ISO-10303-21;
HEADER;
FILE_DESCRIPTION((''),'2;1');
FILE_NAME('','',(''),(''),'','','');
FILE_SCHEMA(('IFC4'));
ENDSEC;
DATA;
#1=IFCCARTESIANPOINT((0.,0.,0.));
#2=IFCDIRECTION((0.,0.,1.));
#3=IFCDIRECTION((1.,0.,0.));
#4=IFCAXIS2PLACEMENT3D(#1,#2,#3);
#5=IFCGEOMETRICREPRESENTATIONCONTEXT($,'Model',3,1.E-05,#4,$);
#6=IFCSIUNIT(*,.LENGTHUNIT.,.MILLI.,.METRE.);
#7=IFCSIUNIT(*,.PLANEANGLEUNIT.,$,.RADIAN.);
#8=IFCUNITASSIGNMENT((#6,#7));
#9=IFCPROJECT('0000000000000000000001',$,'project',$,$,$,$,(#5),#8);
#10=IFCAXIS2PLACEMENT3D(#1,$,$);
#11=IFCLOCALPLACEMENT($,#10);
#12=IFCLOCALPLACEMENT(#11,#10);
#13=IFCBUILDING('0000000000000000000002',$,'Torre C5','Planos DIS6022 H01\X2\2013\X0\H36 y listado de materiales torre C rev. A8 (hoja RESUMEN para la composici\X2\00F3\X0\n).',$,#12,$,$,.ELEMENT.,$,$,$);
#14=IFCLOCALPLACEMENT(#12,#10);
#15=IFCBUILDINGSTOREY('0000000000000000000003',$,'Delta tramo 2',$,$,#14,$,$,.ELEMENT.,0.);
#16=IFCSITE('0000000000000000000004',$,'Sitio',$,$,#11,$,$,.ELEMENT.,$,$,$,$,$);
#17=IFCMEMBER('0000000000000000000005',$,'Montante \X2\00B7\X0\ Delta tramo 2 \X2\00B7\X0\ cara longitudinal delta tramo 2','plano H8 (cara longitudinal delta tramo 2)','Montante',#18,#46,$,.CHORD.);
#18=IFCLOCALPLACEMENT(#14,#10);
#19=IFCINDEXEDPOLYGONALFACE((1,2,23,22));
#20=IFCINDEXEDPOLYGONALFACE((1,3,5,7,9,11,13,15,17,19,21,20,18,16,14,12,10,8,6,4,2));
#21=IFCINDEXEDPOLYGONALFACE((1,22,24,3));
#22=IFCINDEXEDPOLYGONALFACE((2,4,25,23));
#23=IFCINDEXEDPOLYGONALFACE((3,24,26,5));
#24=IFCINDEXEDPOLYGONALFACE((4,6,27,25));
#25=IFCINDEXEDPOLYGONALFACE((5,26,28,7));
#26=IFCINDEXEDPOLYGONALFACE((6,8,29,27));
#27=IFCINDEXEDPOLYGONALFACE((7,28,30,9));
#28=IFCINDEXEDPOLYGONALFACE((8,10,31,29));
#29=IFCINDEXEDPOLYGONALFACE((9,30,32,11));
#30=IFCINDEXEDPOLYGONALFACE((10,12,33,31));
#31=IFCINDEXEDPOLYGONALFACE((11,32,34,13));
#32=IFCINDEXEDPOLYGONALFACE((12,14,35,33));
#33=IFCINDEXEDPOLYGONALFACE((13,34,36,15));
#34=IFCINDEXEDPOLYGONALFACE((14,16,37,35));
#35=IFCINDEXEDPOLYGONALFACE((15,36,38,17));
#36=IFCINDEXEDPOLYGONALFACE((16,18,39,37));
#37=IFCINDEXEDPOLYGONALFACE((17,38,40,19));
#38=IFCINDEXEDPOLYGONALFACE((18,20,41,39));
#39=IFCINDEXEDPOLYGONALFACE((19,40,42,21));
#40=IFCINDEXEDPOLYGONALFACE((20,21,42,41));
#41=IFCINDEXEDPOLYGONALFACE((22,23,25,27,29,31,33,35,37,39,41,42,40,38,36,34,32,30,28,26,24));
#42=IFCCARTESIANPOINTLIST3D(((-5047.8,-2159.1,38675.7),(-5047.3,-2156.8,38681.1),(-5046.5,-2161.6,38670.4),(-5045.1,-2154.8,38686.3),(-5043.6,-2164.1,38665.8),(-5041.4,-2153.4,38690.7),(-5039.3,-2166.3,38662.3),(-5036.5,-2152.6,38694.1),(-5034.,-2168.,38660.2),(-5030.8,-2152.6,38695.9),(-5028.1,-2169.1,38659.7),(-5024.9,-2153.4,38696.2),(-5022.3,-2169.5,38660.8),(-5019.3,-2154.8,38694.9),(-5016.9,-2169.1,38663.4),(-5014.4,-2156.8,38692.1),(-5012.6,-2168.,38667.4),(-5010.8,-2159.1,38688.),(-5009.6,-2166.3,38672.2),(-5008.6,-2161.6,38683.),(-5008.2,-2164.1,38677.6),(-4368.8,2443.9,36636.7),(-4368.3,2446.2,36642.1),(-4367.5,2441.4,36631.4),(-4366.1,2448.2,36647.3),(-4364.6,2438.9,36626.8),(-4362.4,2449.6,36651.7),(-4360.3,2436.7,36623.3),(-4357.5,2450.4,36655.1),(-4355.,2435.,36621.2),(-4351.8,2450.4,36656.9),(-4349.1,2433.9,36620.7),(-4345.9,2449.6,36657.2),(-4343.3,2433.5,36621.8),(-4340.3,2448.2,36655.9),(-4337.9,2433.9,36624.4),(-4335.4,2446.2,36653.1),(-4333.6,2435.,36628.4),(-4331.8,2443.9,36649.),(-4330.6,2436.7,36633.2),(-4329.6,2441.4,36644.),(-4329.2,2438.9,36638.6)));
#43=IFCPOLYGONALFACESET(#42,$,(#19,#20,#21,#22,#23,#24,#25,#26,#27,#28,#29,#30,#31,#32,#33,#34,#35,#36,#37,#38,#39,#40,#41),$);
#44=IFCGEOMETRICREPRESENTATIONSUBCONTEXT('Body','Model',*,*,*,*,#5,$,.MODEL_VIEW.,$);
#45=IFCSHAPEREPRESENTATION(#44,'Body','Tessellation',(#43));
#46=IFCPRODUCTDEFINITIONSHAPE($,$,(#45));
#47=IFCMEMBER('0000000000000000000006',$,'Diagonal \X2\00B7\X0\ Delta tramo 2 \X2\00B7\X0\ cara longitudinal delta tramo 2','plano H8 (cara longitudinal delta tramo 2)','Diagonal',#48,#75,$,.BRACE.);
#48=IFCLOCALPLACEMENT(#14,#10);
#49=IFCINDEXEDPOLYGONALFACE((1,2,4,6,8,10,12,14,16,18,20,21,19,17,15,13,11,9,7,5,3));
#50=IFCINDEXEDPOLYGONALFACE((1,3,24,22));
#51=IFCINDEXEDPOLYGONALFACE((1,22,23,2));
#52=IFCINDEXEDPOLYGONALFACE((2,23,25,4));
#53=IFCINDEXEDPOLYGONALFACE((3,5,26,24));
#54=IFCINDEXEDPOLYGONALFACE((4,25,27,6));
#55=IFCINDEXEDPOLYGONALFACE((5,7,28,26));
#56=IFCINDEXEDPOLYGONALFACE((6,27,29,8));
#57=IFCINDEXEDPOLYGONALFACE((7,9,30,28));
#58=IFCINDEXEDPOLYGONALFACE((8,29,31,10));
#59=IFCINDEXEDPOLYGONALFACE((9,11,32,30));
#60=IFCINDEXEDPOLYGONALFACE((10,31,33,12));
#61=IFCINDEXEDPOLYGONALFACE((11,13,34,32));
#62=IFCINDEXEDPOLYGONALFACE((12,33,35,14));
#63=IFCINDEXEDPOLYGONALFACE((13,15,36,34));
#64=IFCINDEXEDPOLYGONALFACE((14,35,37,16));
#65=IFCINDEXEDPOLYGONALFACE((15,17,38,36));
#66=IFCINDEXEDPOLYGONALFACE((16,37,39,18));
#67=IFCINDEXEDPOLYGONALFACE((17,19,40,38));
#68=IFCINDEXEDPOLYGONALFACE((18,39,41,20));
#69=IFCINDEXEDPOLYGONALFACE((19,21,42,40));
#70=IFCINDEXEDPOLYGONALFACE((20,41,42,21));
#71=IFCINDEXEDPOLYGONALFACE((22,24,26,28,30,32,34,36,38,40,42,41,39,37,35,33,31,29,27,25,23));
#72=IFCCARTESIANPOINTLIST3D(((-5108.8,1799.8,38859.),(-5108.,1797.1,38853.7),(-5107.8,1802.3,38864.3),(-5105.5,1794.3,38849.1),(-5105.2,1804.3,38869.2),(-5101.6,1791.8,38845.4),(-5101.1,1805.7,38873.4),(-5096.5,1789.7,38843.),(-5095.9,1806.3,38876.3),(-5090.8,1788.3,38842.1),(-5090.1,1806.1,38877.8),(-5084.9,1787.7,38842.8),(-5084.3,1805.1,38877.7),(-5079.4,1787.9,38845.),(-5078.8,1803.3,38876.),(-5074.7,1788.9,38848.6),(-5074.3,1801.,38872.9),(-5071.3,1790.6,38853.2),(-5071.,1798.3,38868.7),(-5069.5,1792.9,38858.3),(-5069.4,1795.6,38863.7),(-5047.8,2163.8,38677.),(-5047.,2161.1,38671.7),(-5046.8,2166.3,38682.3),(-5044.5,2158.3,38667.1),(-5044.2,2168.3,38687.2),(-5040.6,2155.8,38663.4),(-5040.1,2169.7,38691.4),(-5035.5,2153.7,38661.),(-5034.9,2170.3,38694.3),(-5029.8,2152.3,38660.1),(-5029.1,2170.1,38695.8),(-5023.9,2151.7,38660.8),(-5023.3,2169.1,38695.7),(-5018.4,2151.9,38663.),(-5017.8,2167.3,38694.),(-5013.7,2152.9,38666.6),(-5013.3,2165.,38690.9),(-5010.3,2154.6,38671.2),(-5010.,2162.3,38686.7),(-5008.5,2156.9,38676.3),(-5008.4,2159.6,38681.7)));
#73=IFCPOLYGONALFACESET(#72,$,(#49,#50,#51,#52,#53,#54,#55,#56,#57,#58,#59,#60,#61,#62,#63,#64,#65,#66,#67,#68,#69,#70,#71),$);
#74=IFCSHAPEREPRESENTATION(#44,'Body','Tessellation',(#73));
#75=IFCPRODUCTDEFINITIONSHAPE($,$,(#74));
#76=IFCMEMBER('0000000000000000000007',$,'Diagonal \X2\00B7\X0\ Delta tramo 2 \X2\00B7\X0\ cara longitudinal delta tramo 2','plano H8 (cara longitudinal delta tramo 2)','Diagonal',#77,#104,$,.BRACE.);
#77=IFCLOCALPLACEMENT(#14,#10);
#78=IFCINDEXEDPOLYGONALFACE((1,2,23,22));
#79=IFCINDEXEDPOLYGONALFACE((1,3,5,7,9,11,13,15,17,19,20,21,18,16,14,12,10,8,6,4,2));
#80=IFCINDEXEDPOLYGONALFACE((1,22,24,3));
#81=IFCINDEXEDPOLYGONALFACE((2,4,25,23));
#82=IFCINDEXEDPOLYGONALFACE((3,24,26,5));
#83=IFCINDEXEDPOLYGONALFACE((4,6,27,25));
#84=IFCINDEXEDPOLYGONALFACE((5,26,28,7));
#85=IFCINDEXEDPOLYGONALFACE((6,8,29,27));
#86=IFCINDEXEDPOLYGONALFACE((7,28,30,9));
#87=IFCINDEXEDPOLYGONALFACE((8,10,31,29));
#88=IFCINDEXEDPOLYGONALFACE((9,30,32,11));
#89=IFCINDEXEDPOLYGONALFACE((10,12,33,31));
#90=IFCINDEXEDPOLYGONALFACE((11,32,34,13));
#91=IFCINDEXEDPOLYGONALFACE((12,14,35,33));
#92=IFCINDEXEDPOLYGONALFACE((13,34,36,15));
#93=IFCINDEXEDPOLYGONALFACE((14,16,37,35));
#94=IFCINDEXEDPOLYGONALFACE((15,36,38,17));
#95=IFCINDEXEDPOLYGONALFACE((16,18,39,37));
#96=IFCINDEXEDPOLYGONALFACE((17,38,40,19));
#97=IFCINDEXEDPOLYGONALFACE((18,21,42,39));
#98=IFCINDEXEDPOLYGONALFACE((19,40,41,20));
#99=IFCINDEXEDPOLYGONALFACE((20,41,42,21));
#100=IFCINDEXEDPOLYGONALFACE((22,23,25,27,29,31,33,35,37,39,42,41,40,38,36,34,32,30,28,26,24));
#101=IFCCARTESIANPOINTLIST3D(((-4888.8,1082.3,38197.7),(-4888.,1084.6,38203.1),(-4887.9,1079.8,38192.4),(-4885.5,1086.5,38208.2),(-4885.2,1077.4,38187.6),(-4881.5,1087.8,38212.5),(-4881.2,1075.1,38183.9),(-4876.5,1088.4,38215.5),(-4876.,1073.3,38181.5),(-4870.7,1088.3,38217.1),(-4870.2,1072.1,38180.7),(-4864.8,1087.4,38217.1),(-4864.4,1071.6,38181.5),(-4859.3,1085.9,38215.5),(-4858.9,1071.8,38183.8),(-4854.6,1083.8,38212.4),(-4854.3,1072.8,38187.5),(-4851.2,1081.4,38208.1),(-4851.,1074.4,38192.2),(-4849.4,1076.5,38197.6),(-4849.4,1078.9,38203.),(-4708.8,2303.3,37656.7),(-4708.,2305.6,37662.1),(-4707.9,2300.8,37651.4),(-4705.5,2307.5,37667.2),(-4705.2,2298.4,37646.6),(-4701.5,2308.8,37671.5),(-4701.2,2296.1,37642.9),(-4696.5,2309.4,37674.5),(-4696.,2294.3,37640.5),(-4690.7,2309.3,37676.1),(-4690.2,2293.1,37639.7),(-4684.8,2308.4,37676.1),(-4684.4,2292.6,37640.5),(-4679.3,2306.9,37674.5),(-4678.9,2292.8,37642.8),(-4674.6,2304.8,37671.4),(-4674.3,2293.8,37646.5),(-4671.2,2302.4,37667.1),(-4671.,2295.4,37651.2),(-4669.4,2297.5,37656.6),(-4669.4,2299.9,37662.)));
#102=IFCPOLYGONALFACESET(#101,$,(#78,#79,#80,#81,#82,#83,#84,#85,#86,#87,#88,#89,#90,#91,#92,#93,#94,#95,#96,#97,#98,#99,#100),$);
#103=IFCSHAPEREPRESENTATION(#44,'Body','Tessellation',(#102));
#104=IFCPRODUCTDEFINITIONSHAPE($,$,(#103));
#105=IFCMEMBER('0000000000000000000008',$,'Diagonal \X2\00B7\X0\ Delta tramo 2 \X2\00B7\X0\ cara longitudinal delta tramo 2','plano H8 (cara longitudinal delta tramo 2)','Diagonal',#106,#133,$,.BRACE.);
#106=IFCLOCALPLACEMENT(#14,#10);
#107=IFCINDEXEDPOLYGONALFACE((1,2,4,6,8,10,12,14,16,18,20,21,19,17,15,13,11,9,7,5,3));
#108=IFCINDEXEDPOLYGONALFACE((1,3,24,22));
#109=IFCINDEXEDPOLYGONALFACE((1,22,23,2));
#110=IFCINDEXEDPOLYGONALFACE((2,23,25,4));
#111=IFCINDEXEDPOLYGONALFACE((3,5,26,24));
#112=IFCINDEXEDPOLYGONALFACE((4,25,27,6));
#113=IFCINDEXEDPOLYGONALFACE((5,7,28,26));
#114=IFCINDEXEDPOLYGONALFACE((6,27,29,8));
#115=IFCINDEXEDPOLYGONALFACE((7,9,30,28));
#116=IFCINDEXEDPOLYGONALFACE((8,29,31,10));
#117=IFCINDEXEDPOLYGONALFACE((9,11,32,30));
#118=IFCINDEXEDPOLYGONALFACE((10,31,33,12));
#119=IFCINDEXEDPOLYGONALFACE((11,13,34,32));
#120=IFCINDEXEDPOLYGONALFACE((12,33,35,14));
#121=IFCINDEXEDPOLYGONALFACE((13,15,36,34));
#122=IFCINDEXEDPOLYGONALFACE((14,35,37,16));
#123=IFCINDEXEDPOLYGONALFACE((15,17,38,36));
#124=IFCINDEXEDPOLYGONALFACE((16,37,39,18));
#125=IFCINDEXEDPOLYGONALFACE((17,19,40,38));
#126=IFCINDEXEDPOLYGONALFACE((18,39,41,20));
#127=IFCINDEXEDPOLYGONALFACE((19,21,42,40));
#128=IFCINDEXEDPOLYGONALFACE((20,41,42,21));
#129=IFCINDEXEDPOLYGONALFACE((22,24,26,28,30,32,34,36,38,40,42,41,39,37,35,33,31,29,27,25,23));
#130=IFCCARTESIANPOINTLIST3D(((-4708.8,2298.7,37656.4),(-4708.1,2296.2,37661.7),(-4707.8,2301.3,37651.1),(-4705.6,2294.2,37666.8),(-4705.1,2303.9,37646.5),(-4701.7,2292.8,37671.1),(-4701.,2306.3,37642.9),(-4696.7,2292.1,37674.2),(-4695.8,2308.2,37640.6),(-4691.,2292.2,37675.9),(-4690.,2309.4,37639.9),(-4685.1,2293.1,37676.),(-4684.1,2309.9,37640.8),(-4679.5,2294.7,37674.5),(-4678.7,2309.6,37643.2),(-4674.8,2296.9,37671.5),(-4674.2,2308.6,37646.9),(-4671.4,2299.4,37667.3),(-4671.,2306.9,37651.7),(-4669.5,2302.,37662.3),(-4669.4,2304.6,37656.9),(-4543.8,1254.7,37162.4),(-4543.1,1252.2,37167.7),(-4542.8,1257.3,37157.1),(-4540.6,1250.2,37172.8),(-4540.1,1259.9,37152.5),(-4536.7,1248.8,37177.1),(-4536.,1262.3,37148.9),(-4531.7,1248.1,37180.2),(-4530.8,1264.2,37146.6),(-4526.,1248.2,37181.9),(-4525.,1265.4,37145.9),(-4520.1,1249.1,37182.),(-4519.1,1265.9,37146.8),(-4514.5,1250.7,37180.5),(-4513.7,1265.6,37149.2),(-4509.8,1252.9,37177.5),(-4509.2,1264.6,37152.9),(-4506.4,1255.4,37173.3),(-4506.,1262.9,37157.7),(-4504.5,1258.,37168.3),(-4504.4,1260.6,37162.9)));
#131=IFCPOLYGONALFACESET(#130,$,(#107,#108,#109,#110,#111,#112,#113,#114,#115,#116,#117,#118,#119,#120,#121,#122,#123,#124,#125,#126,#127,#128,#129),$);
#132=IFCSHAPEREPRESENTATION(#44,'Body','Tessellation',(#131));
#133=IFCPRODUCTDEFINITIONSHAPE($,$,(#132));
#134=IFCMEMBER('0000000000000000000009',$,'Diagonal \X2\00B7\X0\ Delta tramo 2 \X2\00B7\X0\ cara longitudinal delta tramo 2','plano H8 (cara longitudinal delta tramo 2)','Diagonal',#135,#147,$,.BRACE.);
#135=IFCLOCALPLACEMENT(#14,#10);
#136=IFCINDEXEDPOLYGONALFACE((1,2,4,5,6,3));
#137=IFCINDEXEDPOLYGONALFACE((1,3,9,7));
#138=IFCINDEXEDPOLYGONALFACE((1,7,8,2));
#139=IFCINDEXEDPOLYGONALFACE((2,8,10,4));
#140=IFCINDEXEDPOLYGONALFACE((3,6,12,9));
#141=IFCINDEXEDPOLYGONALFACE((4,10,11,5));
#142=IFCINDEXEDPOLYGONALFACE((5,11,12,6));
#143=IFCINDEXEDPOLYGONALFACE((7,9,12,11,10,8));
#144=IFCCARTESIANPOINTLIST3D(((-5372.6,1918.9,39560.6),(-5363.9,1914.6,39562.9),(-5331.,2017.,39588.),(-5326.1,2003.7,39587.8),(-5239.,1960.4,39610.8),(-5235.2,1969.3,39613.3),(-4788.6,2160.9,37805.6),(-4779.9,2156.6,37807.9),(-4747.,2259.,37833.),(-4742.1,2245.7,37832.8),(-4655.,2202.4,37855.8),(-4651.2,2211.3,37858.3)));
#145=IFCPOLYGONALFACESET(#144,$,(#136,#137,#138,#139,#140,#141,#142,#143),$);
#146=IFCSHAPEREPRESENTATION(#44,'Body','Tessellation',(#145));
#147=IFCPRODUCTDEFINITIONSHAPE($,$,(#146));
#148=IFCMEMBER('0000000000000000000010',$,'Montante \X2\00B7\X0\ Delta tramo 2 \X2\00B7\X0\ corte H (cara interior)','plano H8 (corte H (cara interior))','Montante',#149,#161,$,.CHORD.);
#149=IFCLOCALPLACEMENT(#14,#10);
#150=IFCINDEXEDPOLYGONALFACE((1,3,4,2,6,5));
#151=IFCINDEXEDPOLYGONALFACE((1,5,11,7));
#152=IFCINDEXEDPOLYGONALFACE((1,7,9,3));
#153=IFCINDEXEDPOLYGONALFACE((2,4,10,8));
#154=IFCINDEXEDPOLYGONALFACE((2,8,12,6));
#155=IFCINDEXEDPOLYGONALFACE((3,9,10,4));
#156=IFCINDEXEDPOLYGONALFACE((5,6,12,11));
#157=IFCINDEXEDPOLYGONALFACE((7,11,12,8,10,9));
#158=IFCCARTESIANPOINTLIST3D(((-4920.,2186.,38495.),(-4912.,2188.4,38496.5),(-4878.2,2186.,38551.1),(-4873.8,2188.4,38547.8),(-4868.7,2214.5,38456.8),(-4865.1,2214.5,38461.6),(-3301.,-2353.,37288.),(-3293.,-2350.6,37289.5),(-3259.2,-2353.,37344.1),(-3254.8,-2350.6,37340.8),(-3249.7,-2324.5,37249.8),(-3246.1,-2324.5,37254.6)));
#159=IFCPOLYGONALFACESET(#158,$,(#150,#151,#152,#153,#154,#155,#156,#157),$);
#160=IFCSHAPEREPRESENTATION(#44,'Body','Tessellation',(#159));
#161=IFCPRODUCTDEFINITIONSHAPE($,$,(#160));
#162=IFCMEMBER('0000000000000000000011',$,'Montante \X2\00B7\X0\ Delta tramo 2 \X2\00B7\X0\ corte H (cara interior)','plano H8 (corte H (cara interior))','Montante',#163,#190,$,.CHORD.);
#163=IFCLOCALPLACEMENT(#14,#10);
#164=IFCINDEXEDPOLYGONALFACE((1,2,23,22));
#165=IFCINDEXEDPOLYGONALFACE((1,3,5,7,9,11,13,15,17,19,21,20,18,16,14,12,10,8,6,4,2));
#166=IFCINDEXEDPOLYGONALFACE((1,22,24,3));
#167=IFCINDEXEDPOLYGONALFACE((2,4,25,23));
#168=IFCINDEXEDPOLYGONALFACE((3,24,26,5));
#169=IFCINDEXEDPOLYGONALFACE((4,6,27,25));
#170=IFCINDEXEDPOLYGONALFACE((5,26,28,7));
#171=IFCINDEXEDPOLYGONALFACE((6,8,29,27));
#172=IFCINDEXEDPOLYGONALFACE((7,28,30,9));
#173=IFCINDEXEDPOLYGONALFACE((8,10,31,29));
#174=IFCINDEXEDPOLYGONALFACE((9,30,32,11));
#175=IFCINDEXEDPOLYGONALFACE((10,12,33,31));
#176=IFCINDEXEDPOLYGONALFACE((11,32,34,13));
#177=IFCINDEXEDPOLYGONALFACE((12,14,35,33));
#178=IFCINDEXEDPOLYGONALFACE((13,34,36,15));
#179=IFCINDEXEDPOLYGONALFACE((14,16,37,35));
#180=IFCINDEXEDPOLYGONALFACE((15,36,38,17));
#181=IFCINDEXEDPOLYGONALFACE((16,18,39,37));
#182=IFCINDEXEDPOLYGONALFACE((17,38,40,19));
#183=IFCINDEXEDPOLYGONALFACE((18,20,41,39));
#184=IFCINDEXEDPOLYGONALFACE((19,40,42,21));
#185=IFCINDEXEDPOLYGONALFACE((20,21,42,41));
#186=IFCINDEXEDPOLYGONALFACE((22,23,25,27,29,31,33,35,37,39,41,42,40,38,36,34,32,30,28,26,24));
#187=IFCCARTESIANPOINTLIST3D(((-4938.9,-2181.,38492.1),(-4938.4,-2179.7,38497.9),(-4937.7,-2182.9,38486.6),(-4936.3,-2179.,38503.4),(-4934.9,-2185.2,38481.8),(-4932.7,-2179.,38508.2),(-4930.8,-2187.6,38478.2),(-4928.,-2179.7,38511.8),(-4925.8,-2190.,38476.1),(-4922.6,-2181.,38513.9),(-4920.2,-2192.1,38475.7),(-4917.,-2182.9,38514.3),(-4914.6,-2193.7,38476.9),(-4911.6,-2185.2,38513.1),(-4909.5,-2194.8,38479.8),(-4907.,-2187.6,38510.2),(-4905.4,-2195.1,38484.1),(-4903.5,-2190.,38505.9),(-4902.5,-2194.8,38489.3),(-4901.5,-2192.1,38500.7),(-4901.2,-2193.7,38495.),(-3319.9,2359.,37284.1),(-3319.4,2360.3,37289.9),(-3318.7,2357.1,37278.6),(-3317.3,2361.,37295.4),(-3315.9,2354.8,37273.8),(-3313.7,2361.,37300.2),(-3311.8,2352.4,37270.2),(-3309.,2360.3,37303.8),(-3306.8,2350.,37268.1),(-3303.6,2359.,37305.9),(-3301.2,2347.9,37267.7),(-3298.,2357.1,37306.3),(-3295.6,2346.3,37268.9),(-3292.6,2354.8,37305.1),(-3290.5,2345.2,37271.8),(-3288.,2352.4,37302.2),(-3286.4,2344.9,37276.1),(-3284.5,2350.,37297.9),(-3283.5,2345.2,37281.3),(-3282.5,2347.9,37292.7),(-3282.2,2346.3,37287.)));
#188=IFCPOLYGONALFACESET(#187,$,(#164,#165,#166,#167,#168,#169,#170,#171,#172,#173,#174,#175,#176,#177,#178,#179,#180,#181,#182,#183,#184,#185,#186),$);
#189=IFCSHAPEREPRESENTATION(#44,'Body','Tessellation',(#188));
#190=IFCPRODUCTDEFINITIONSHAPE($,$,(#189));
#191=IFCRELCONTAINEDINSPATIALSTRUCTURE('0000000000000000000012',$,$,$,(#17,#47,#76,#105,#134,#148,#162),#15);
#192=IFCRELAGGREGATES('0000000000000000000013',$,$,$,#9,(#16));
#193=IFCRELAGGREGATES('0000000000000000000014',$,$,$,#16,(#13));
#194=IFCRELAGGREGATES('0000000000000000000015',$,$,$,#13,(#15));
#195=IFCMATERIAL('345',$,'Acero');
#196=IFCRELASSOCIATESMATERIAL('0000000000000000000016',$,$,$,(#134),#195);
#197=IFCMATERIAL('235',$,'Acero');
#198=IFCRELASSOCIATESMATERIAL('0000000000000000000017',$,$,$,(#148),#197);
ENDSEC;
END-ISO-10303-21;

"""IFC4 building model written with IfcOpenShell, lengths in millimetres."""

from ifc_helpers import new_model, si_unit, frame, frame_2d, origin, origin_with_axes, place, context, subcontext, project, spatial, circle, l_section, extrude, material, element, save


model = new_model("IFC4")

# Units and contexts
model_context = context("Model", 3, precision=1e-05, world=origin_with_axes())
body_context = subcontext(model_context, "Body", "Model", "MODEL_VIEW")
ifc_project = project(units=[si_unit("LENGTHUNIT", "METRE", prefix="MILLI"), si_unit("PLANEANGLEUNIT", "RADIAN")], contexts=[model_context])

# Site, building, storey
site_placement = place(None, origin())
site = spatial("IfcSite", under=ifc_project, at=site_placement, Name="Sitio", CompositionType="ELEMENT")
building_placement = place(site_placement, origin())
building = spatial("IfcBuilding", under=site, at=building_placement, Name="Torre C5", Description="Planos DIS6022 H01–H36 y listado de materiales torre C rev. A8 (hoja RESUMEN para la composición).", CompositionType="ELEMENT")
storey_placement = place(building_placement, origin())
storey = spatial("IfcBuildingStorey", under=building, at=storey_placement, Name="Delta tramo 2", CompositionType="ELEMENT", Elevation=0.0)

# Members
ifc_material_1 = material(Name="345", Category="Acero")
member_1_placement = place(storey_placement, frame((-4349.0, 2442.0, 36639.0), z_axis=(-0.133662, -0.906106, 0.40138), x_axis=(0.286283, -0.42305, -0.859692)))
element("IfcMember", 1, at=member_1_placement, inside=storey, Name="Montante · Delta tramo 2 · cara longitudinal delta tramo 2", Description="plano H8 (cara longitudinal delta tramo 2)", ObjectType="Montante", PredefinedType="CHORD", context=body_context, shape_type="SweptSolid", body=[
    extrude(circle(Radius=20.0), None, (0.0, 0.0, 1.0), 5080.0),
])
member_2_placement = place(storey_placement, frame((-5028.0, 2161.0, 38678.0), z_axis=(-0.148234, -0.884546, 0.442273), x_axis=(0.975269, -0.204886, -0.082896)))
element("IfcMember", 2, at=member_2_placement, inside=storey, Name="Diagonal · Delta tramo 2 · cara longitudinal delta tramo 2", Description="plano H8 (cara longitudinal delta tramo 2)", ObjectType="Diagonal", PredefinedType="BRACE", context=body_context, shape_type="SweptSolid", body=[
    extrude(circle(Radius=20.0), None, (0.0, 0.0, 1.0), 411.5),
])
member_3_placement = place(storey_placement, frame((-4689.0, 2301.0, 37658.0), z_axis=(-0.133575, -0.906081, 0.401466), x_axis=(0.981661, -0.176564, -0.071878)))
element("IfcMember", 3, at=member_3_placement, inside=storey, Name="Diagonal · Delta tramo 2 · cara longitudinal delta tramo 2", Description="plano H8 (cara longitudinal delta tramo 2)", ObjectType="Diagonal", PredefinedType="BRACE", context=body_context, shape_type="SweptSolid", body=[
    extrude(circle(Radius=20.0), None, (0.0, 0.0, 1.0), 1347.6),
])
member_4_placement = place(storey_placement, frame((-4524.0, 1257.0, 37164.0), z_axis=(-0.141424, 0.894829, 0.423415), x_axis=(0.975028, 0.051927, 0.215926)))
element("IfcMember", 4, at=member_4_placement, inside=storey, Name="Diagonal · Delta tramo 2 · cara longitudinal delta tramo 2", Description="plano H8 (cara longitudinal delta tramo 2)", ObjectType="Diagonal", PredefinedType="BRACE", context=body_context, shape_type="SweptSolid", body=[
    extrude(circle(Radius=20.0), None, (0.0, 0.0, 1.0), 1166.7),
])
member_5_placement = place(storey_placement, frame((-5331.0, 2017.0, 39588.0), z_axis=(0.313073, 0.129732, -0.940827), x_axis=(0.871133, -0.433819, 0.230061)))
element("IfcMember", 5, at=member_5_placement, inside=storey, material=ifc_material_1, Name="Diagonal · Delta tramo 2 · cara longitudinal delta tramo 2", Description="plano H8 (cara longitudinal delta tramo 2)", ObjectType="Diagonal", PredefinedType="BRACE", context=body_context, shape_type="SweptSolid", body=[
    extrude(l_section(Depth=110.0, Width=110.0, Thickness=10.0, at=frame_2d((55.0, 55.0))), None, (0.0, 0.0, 1.0), 1865.4),
])
ifc_material_2 = material(Name="235", Category="Acero")
member_6_placement = place(storey_placement, frame((-4920.0, 2186.0, 38495.0), z_axis=(0.325889, -0.913656, -0.242957), x_axis=(0.732497, 0.406487, -0.546092)))
element("IfcMember", 6, at=member_6_placement, inside=storey, material=ifc_material_2, Name="Montante · Delta tramo 2 · corte H (cara interior)", Description="plano H8 (corte H (cara interior))", ObjectType="Montante", PredefinedType="CHORD", context=body_context, shape_type="SweptSolid", body=[
    extrude(l_section(Depth=70.0, Width=70.0, Thickness=6.0, at=frame_2d((35.0, 35.0))), None, (0.0, 0.0, 1.0), 4968.0),
])
member_7_placement = place(storey_placement, frame((-3301.0, 2353.0, 37287.0), z_axis=(-0.325813, -0.913645, 0.243102), x_axis=(0.732271, -0.406513, -0.546376)))
element("IfcMember", 7, at=member_7_placement, inside=storey, Name="Montante · Delta tramo 2 · corte H (cara interior)", Description="plano H8 (corte H (cara interior))", ObjectType="Montante", PredefinedType="CHORD", context=body_context, shape_type="SweptSolid", body=[
    extrude(circle(Radius=20.0), None, (0.0, 0.0, 1.0), 4969.1),
])

save(model, "model.ifc")
